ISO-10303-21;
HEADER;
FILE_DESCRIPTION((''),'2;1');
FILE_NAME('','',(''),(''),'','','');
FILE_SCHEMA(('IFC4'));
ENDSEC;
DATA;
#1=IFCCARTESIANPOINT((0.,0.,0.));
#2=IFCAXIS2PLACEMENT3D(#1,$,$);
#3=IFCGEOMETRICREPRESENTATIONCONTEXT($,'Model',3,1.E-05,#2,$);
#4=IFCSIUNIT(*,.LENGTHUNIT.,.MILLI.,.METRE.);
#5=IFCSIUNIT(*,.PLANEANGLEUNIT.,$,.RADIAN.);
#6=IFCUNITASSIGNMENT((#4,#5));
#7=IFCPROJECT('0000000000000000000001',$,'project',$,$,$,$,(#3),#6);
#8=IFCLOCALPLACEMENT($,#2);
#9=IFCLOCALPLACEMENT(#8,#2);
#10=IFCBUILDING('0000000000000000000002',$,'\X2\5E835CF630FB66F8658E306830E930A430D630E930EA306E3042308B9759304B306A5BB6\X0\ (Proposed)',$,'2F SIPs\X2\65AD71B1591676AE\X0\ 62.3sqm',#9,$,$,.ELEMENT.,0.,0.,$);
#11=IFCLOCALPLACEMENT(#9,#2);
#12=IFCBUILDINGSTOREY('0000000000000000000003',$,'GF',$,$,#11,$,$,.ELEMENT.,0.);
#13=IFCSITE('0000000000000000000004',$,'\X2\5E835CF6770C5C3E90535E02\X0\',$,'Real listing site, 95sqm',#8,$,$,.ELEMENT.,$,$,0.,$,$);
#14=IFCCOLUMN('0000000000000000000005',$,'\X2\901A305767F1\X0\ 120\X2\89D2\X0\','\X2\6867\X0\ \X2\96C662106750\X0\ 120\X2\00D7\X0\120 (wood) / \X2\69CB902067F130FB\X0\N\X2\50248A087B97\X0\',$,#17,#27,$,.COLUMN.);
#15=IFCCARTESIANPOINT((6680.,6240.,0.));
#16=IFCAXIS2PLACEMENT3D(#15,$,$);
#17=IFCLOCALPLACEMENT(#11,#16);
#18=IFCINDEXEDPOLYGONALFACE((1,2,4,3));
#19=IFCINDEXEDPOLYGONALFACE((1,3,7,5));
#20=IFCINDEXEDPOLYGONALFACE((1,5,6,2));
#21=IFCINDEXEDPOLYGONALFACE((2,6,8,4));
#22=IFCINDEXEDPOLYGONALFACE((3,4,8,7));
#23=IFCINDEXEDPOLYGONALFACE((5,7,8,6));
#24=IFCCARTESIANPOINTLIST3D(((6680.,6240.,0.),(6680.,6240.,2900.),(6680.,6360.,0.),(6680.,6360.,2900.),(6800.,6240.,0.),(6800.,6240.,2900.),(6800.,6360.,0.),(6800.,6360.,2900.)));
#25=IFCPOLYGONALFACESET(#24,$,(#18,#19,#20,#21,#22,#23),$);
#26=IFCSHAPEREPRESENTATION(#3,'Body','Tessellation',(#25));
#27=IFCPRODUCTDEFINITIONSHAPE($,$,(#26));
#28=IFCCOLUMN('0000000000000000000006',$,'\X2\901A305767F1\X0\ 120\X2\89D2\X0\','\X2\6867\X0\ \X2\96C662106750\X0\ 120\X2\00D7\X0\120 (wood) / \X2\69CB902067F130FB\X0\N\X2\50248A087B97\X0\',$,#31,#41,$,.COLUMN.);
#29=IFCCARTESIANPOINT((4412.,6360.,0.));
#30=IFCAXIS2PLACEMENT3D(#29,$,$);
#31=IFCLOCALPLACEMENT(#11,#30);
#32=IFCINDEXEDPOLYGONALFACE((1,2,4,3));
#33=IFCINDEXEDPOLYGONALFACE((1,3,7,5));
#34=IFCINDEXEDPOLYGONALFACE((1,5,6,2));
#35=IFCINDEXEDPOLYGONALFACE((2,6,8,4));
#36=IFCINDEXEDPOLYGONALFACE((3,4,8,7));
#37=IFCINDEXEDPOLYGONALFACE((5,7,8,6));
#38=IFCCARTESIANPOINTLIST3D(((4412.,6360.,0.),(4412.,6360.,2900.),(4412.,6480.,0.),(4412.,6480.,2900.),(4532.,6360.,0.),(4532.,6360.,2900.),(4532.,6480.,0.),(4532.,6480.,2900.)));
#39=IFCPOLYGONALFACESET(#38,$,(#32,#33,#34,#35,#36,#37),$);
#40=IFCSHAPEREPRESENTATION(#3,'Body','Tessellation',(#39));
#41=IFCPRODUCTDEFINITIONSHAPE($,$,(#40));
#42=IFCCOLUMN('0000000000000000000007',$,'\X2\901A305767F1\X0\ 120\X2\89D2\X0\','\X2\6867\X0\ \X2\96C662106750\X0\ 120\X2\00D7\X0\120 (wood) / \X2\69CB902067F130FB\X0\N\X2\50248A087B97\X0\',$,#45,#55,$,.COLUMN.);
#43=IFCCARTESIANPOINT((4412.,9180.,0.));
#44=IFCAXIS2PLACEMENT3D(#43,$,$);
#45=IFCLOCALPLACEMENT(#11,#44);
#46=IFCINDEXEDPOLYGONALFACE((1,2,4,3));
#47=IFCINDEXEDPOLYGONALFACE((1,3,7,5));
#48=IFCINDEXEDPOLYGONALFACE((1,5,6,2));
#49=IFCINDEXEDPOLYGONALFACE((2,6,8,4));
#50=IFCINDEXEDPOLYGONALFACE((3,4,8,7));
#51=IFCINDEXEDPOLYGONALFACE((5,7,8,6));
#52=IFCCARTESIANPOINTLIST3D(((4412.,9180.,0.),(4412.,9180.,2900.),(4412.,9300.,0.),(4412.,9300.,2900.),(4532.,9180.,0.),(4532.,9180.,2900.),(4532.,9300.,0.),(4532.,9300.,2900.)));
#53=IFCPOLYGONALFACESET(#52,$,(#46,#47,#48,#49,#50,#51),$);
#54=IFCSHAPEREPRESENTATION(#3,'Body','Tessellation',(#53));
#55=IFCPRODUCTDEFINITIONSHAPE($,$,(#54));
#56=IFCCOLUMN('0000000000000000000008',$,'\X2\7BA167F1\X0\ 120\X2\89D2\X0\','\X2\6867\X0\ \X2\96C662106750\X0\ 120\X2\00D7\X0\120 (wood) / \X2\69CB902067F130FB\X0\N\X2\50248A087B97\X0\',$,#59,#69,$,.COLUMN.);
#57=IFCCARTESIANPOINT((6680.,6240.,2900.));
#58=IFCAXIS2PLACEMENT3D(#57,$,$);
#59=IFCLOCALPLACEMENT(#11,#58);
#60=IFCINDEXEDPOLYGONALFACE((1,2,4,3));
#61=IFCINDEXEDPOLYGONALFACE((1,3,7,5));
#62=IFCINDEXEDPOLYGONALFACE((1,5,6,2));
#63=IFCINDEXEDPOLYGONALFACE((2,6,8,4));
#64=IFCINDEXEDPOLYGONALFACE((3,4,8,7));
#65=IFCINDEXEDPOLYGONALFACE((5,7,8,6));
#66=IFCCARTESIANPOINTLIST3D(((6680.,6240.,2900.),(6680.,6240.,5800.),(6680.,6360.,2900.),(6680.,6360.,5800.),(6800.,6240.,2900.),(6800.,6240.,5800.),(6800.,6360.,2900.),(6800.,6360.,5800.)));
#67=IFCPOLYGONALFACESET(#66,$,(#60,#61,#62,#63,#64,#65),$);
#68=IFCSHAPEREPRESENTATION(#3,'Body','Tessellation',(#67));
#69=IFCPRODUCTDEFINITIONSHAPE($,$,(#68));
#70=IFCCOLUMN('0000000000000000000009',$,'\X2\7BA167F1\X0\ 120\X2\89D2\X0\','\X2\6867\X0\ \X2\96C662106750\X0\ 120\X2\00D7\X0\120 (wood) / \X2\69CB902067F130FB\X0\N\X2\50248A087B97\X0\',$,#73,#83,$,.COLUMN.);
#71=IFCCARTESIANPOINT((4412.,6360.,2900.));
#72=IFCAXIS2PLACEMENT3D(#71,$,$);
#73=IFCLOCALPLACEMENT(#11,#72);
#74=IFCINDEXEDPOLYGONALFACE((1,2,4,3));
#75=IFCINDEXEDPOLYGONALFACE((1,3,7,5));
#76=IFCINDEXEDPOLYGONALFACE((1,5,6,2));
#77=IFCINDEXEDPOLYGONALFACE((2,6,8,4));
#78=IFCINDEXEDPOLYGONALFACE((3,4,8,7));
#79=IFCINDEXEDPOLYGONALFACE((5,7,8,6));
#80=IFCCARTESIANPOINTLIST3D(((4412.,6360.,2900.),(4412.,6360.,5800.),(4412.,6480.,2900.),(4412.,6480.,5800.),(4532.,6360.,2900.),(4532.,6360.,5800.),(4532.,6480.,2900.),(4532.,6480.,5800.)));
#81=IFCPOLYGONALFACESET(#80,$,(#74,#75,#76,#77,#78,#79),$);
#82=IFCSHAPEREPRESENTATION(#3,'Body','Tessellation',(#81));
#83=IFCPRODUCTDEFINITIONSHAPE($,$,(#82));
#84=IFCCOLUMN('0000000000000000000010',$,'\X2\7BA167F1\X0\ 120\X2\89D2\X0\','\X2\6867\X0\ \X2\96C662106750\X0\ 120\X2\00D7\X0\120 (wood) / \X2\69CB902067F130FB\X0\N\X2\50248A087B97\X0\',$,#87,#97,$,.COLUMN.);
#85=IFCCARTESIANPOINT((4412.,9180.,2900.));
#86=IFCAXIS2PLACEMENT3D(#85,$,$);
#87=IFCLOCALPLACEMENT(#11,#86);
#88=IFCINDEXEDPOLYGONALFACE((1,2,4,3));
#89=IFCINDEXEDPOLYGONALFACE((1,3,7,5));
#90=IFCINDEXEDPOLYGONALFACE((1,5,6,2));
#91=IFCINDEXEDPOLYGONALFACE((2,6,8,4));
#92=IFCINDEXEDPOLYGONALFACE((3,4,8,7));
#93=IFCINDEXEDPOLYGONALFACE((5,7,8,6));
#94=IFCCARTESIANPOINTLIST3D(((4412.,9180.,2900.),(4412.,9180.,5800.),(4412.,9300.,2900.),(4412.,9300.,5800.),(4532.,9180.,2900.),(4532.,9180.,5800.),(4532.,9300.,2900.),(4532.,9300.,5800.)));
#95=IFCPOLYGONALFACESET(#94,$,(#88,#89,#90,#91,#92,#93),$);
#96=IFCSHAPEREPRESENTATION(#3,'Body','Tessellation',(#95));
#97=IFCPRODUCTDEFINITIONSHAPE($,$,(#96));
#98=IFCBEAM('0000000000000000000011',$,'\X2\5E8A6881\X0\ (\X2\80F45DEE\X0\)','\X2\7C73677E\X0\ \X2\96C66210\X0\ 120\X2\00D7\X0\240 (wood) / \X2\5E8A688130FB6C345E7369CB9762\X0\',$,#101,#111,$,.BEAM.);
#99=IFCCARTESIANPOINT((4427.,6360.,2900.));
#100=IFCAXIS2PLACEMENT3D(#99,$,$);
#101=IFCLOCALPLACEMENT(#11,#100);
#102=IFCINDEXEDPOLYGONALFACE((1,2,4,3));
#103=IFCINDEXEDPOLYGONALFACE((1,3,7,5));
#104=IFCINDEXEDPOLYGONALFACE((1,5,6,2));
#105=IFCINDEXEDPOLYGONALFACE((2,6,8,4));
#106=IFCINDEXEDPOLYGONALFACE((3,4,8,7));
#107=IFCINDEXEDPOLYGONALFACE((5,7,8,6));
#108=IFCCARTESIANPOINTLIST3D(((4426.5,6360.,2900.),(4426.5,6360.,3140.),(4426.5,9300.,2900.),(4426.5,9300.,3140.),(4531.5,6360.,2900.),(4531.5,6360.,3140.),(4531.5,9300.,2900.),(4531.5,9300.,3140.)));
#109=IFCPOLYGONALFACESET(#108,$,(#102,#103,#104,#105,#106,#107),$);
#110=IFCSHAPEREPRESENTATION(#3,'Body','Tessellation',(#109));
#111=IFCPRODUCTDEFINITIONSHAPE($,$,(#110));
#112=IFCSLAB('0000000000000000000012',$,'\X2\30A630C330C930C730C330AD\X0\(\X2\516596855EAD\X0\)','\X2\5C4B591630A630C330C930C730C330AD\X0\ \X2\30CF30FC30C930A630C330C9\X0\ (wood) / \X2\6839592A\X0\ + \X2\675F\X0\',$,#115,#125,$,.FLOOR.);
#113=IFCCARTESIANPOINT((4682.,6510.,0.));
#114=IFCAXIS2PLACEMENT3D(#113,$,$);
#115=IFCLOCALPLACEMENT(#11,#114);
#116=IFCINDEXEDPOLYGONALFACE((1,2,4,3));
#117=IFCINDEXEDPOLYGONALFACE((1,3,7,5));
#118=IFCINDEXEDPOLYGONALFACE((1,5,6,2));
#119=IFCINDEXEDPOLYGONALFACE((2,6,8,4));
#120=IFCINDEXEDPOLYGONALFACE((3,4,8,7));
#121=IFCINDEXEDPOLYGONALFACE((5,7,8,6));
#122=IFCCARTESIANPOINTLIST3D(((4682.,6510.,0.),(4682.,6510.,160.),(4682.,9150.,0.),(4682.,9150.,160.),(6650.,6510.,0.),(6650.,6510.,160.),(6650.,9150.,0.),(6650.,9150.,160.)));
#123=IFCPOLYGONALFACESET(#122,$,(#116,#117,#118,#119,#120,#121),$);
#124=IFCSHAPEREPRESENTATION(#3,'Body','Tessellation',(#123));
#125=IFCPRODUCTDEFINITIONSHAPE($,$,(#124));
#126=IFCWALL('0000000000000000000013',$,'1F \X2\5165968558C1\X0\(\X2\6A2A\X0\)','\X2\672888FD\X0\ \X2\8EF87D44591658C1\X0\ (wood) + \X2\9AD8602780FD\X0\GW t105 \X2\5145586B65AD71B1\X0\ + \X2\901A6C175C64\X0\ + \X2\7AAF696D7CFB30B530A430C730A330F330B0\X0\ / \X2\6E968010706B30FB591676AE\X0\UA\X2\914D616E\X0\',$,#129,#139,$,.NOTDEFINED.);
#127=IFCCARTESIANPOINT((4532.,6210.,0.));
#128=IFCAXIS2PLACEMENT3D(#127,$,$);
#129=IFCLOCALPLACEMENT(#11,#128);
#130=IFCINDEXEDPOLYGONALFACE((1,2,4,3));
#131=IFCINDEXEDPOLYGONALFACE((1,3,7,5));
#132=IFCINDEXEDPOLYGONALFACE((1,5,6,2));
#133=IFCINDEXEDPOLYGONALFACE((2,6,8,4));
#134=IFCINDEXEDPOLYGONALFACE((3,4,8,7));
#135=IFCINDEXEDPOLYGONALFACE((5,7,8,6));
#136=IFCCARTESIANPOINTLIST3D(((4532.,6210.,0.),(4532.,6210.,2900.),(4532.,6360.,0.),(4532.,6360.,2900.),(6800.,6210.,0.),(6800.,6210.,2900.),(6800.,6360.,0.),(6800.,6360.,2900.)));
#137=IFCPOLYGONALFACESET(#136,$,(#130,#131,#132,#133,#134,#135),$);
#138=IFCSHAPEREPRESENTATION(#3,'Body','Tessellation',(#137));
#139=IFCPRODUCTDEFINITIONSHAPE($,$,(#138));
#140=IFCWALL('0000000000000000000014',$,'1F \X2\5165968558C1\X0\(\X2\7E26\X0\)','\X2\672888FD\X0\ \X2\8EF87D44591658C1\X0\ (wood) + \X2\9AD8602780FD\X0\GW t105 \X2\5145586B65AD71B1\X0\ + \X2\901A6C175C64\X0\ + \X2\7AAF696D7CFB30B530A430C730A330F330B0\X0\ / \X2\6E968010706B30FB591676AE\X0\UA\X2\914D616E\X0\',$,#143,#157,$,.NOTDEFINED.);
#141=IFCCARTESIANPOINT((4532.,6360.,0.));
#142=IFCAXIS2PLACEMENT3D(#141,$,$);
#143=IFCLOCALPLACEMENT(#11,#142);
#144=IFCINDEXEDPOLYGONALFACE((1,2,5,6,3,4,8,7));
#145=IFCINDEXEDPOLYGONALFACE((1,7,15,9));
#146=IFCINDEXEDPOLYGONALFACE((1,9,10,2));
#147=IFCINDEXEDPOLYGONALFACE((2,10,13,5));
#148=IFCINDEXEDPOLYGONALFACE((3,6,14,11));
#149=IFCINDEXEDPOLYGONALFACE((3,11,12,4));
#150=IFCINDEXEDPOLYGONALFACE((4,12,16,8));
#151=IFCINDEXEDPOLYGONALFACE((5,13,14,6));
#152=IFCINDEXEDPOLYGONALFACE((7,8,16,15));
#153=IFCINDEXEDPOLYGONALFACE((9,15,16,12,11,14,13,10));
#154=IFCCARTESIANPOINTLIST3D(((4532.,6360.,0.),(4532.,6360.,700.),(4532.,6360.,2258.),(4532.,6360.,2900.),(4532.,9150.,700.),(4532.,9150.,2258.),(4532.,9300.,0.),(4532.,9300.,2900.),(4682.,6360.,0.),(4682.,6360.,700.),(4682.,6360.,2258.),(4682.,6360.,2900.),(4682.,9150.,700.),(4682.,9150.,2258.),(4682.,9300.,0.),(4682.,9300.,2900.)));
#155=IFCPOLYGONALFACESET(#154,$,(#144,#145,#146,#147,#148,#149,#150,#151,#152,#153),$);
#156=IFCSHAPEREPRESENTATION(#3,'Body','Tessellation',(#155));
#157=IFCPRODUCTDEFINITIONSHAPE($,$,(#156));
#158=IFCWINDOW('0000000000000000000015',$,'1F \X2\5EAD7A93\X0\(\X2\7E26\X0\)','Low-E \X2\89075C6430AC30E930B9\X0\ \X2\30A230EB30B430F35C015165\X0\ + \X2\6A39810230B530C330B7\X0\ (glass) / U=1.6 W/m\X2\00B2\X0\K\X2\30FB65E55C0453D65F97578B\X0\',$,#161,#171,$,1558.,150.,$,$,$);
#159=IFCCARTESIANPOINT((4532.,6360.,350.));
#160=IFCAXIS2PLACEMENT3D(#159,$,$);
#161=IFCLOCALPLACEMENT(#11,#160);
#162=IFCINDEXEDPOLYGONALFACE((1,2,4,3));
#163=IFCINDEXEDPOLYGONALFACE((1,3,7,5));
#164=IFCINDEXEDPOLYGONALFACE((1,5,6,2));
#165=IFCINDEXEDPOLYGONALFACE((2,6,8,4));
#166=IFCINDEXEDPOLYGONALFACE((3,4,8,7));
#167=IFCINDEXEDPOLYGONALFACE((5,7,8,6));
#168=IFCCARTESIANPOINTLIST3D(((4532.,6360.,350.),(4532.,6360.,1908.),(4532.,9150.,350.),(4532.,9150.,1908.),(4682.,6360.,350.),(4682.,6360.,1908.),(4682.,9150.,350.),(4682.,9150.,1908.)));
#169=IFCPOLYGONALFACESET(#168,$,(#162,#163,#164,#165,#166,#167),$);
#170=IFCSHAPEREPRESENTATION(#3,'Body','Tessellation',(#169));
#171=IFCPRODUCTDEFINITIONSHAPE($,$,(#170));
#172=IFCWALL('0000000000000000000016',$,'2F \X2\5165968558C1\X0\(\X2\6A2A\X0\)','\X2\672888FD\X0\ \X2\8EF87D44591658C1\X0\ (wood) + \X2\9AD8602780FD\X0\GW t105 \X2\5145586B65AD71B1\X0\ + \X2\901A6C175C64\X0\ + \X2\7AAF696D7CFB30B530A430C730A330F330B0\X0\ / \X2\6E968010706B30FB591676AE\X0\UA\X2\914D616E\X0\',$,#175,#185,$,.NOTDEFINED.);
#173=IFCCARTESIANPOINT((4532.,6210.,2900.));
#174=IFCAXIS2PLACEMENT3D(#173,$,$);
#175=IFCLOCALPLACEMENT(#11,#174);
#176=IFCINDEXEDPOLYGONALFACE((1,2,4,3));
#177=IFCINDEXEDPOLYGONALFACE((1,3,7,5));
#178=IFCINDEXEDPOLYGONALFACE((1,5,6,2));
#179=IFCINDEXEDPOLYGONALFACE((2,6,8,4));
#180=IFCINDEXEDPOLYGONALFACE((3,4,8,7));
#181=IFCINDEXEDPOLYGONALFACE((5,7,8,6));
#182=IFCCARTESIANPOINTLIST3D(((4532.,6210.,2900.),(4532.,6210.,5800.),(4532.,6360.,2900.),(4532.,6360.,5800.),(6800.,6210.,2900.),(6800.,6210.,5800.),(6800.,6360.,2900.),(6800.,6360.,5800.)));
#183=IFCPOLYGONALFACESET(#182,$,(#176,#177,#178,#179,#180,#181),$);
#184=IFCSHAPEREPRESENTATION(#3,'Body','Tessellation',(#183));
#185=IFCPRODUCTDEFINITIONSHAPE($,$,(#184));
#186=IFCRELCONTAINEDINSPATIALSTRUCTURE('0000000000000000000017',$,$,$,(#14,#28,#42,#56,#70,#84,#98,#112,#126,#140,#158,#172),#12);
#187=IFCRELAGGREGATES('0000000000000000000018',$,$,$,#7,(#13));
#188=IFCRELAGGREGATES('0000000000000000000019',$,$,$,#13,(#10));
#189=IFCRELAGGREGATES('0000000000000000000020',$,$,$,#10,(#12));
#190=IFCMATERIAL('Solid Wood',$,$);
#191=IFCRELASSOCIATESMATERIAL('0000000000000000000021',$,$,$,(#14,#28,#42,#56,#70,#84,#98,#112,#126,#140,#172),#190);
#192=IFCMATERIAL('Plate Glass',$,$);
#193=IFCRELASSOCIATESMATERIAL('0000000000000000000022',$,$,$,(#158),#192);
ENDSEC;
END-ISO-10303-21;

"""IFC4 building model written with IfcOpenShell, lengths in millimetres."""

from ifc_helpers import new_model, si_unit, frame, frame_2d, origin, place, context, project, spatial, rectangle, extrude, material, element, fill, save


model = new_model("IFC4")

# Units and contexts
model_context = context("Model", 3, precision=1e-05, world=origin())
ifc_project = project(units=[si_unit("LENGTHUNIT", "METRE", prefix="MILLI"), si_unit("PLANEANGLEUNIT", "RADIAN")], contexts=[model_context])

# Site, building, storey
site_placement = place(None, origin())
site = spatial("IfcSite", under=ifc_project, at=site_placement, Name="広島県尾道市", ObjectType="Real listing site, 95sqm", CompositionType="ELEMENT", RefElevation=0.0)
building_placement = place(site_placement, origin())
building = spatial("IfcBuilding", under=site, at=building_placement, Name="広島・書斎とライブラリのある静かな家 (Proposed)", ObjectType="2F SIPs断熱外皮 62.3sqm", CompositionType="ELEMENT", ElevationOfRefHeight=0.0, ElevationOfTerrain=0.0)
storey_placement = place(building_placement, origin())
storey = spatial("IfcBuildingStorey", under=building, at=storey_placement, Name="GF", CompositionType="ELEMENT", Elevation=0.0)

# Columns
ifc_material_1 = material(Name="Solid Wood")
column_1_placement = place(storey_placement, frame((6680.0, 6240.0, 0.0)))
element("IfcColumn", 1, at=column_1_placement, inside=storey, material=ifc_material_1, Name="通し柱 120角", Description="桧 集成材 120×120 (wood) / 構造柱・N値計算", PredefinedType="COLUMN", context=model_context, shape_type="SweptSolid", body=[
    extrude(rectangle(XDim=120.0, YDim=120.0, at=frame_2d((60.0, 60.0))), frame((6680.0, 6240.0, 0.0)), (0.0, 0.0, 1.0), 2900.0),
])
column_2_placement = place(storey_placement, frame((4412.0, 6360.0, 0.0)))
element("IfcColumn", 2, at=column_2_placement, inside=storey, material=ifc_material_1, Name="通し柱 120角", Description="桧 集成材 120×120 (wood) / 構造柱・N値計算", PredefinedType="COLUMN", context=model_context, shape_type="SweptSolid", body=[
    extrude(rectangle(XDim=120.0, YDim=120.0, at=frame_2d((60.0, 60.0))), frame((4412.0, 6360.0, 0.0)), (0.0, 0.0, 1.0), 2900.0),
])
column_3_placement = place(storey_placement, frame((4412.0, 9180.0, 0.0)))
element("IfcColumn", 3, at=column_3_placement, inside=storey, material=ifc_material_1, Name="通し柱 120角", Description="桧 集成材 120×120 (wood) / 構造柱・N値計算", PredefinedType="COLUMN", context=model_context, shape_type="SweptSolid", body=[
    extrude(rectangle(XDim=120.0, YDim=120.0, at=frame_2d((60.0, 60.0))), frame((4412.0, 9180.0, 0.0)), (0.0, 0.0, 1.0), 2900.0),
])
column_4_placement = place(storey_placement, frame((6680.0, 6240.0, 2900.0)))
element("IfcColumn", 4, at=column_4_placement, inside=storey, material=ifc_material_1, Name="管柱 120角", Description="桧 集成材 120×120 (wood) / 構造柱・N値計算", PredefinedType="COLUMN", context=model_context, shape_type="SweptSolid", body=[
    extrude(rectangle(XDim=120.0, YDim=120.0, at=frame_2d((60.0, 60.0))), frame((6680.0, 6240.0, 2900.0)), (0.0, 0.0, 1.0), 2900.0),
])
column_5_placement = place(storey_placement, frame((4412.0, 6360.0, 2900.0)))
element("IfcColumn", 5, at=column_5_placement, inside=storey, material=ifc_material_1, Name="管柱 120角", Description="桧 集成材 120×120 (wood) / 構造柱・N値計算", PredefinedType="COLUMN", context=model_context, shape_type="SweptSolid", body=[
    extrude(rectangle(XDim=120.0, YDim=120.0, at=frame_2d((60.0, 60.0))), frame((4412.0, 6360.0, 2900.0)), (0.0, 0.0, 1.0), 2900.0),
])
column_6_placement = place(storey_placement, frame((4412.0, 9180.0, 2900.0)))
element("IfcColumn", 6, at=column_6_placement, inside=storey, material=ifc_material_1, Name="管柱 120角", Description="桧 集成材 120×120 (wood) / 構造柱・N値計算", PredefinedType="COLUMN", context=model_context, shape_type="SweptSolid", body=[
    extrude(rectangle(XDim=120.0, YDim=120.0, at=frame_2d((60.0, 60.0))), frame((4412.0, 9180.0, 2900.0)), (0.0, 0.0, 1.0), 2900.0),
])

# Beam
beam_1_placement = place(storey_placement, frame((4427.0, 6360.0, 2900.0)))
element("IfcBeam", 7, at=beam_1_placement, inside=storey, material=ifc_material_1, Name="床梁 (胴差)", Description="米松 集成 120×240 (wood) / 床梁・水平構面", PredefinedType="BEAM", context=model_context, shape_type="SweptSolid", body=[
    extrude(rectangle(XDim=105.0, YDim=2940.0, at=frame_2d((52.0, 1470.0))), frame((4427.0, 6360.0, 2900.0)), (0.0, 0.0, 1.0), 240.0),
])

# Slab
slab_placement = place(storey_placement, frame((4682.0, 6510.0, 0.0)))
element("IfcSlab", 8, at=slab_placement, inside=storey, material=ifc_material_1, Name="ウッドデッキ(入隅庭)", Description="屋外ウッドデッキ ハードウッド (wood) / 根太 + 束", PredefinedType="FLOOR", context=model_context, shape_type="SweptSolid", body=[
    extrude(rectangle(XDim=1968.0, YDim=2640.0, at=frame_2d((984.0, 1320.0))), frame((4682.0, 6510.0, 0.0)), (0.0, 0.0, 1.0), 160.0),
])

# Wall
wall_1_placement = place(storey_placement, frame((4532.0, 6210.0, 0.0)))
element("IfcWall", 9, at=wall_1_placement, inside=storey, material=ifc_material_1, Name="1F 入隅壁(横)", Description="木製 軸組外壁 (wood) + 高性能GW t105 充填断熱 + 通気層 + 窯業系サイディング / 準耐火・外皮UA配慮", PredefinedType="NOTDEFINED", context=model_context, shape_type="SweptSolid", body=[
    extrude(rectangle(XDim=2268.0, YDim=150.0, at=frame_2d((1134.0, 75.0))), frame((4532.0, 6210.0, 0.0)), (0.0, 0.0, 1.0), 2900.0),
])

# Wall, opening, window
wall_2_placement = place(storey_placement, frame((4532.0, 6360.0, 0.0)))
wall_2 = element("IfcWall", 10, at=wall_2_placement, inside=storey, material=ifc_material_1, Name="1F 入隅壁(縦)", Description="木製 軸組外壁 (wood) + 高性能GW t105 充填断熱 + 通気層 + 窯業系サイディング / 準耐火・外皮UA配慮", PredefinedType="NOTDEFINED", context=model_context, shape_type="SweptSolid", body=[
    extrude(rectangle(XDim=150.0, YDim=2940.0, at=frame_2d((75.0, 1470.0))), frame((4532.0, 6360.0, 0.0)), (0.0, 0.0, 1.0), 2900.0),
])
opening_1_placement = place(storey_placement, frame((4532.0, 6360.0, 350.0)))
opening_1 = element("IfcOpeningElement", 11, at=opening_1_placement, cuts=wall_2, PredefinedType="NOTDEFINED", context=model_context, shape_type="SweptSolid", body=[
    extrude(rectangle(XDim=150.0, YDim=2790.0, at=frame_2d((75.0, 1395.0))), frame((4532.0, 6360.0, 350.0)), (0.0, 0.0, 1.0), 1558.0),
])
ifc_material_2 = material(Name="Plate Glass")
window_1_placement = place(storey_placement, frame((4532.0, 6360.0, 350.0)))
window_1 = element("IfcWindow", 12, at=window_1_placement, inside=storey, material=ifc_material_2, Name="1F 庭窓(縦)", Description="Low-E 複層ガラス アルゴン封入 + 樹脂サッシ (glass) / U=1.6 W/m²K・日射取得型", OverallHeight=1558.0, OverallWidth=150.0, context=model_context, shape_type="SweptSolid", body=[
    extrude(rectangle(XDim=150.0, YDim=2790.0, at=frame_2d((75.0, 1395.0))), frame((4532.0, 6360.0, 350.0)), (0.0, 0.0, 1.0), 1558.0),
])
fill(opening_1, window_1)

# Wall
wall_3_placement = place(storey_placement, frame((4532.0, 6210.0, 2900.0)))
element("IfcWall", 13, at=wall_3_placement, inside=storey, material=ifc_material_1, Name="2F 入隅壁(横)", Description="木製 軸組外壁 (wood) + 高性能GW t105 充填断熱 + 通気層 + 窯業系サイディング / 準耐火・外皮UA配慮", PredefinedType="NOTDEFINED", context=model_context, shape_type="SweptSolid", body=[
    extrude(rectangle(XDim=2268.0, YDim=150.0, at=frame_2d((1134.0, 75.0))), frame((4532.0, 6210.0, 2900.0)), (0.0, 0.0, 1.0), 2900.0),
])

save(model, "model.ifc")
